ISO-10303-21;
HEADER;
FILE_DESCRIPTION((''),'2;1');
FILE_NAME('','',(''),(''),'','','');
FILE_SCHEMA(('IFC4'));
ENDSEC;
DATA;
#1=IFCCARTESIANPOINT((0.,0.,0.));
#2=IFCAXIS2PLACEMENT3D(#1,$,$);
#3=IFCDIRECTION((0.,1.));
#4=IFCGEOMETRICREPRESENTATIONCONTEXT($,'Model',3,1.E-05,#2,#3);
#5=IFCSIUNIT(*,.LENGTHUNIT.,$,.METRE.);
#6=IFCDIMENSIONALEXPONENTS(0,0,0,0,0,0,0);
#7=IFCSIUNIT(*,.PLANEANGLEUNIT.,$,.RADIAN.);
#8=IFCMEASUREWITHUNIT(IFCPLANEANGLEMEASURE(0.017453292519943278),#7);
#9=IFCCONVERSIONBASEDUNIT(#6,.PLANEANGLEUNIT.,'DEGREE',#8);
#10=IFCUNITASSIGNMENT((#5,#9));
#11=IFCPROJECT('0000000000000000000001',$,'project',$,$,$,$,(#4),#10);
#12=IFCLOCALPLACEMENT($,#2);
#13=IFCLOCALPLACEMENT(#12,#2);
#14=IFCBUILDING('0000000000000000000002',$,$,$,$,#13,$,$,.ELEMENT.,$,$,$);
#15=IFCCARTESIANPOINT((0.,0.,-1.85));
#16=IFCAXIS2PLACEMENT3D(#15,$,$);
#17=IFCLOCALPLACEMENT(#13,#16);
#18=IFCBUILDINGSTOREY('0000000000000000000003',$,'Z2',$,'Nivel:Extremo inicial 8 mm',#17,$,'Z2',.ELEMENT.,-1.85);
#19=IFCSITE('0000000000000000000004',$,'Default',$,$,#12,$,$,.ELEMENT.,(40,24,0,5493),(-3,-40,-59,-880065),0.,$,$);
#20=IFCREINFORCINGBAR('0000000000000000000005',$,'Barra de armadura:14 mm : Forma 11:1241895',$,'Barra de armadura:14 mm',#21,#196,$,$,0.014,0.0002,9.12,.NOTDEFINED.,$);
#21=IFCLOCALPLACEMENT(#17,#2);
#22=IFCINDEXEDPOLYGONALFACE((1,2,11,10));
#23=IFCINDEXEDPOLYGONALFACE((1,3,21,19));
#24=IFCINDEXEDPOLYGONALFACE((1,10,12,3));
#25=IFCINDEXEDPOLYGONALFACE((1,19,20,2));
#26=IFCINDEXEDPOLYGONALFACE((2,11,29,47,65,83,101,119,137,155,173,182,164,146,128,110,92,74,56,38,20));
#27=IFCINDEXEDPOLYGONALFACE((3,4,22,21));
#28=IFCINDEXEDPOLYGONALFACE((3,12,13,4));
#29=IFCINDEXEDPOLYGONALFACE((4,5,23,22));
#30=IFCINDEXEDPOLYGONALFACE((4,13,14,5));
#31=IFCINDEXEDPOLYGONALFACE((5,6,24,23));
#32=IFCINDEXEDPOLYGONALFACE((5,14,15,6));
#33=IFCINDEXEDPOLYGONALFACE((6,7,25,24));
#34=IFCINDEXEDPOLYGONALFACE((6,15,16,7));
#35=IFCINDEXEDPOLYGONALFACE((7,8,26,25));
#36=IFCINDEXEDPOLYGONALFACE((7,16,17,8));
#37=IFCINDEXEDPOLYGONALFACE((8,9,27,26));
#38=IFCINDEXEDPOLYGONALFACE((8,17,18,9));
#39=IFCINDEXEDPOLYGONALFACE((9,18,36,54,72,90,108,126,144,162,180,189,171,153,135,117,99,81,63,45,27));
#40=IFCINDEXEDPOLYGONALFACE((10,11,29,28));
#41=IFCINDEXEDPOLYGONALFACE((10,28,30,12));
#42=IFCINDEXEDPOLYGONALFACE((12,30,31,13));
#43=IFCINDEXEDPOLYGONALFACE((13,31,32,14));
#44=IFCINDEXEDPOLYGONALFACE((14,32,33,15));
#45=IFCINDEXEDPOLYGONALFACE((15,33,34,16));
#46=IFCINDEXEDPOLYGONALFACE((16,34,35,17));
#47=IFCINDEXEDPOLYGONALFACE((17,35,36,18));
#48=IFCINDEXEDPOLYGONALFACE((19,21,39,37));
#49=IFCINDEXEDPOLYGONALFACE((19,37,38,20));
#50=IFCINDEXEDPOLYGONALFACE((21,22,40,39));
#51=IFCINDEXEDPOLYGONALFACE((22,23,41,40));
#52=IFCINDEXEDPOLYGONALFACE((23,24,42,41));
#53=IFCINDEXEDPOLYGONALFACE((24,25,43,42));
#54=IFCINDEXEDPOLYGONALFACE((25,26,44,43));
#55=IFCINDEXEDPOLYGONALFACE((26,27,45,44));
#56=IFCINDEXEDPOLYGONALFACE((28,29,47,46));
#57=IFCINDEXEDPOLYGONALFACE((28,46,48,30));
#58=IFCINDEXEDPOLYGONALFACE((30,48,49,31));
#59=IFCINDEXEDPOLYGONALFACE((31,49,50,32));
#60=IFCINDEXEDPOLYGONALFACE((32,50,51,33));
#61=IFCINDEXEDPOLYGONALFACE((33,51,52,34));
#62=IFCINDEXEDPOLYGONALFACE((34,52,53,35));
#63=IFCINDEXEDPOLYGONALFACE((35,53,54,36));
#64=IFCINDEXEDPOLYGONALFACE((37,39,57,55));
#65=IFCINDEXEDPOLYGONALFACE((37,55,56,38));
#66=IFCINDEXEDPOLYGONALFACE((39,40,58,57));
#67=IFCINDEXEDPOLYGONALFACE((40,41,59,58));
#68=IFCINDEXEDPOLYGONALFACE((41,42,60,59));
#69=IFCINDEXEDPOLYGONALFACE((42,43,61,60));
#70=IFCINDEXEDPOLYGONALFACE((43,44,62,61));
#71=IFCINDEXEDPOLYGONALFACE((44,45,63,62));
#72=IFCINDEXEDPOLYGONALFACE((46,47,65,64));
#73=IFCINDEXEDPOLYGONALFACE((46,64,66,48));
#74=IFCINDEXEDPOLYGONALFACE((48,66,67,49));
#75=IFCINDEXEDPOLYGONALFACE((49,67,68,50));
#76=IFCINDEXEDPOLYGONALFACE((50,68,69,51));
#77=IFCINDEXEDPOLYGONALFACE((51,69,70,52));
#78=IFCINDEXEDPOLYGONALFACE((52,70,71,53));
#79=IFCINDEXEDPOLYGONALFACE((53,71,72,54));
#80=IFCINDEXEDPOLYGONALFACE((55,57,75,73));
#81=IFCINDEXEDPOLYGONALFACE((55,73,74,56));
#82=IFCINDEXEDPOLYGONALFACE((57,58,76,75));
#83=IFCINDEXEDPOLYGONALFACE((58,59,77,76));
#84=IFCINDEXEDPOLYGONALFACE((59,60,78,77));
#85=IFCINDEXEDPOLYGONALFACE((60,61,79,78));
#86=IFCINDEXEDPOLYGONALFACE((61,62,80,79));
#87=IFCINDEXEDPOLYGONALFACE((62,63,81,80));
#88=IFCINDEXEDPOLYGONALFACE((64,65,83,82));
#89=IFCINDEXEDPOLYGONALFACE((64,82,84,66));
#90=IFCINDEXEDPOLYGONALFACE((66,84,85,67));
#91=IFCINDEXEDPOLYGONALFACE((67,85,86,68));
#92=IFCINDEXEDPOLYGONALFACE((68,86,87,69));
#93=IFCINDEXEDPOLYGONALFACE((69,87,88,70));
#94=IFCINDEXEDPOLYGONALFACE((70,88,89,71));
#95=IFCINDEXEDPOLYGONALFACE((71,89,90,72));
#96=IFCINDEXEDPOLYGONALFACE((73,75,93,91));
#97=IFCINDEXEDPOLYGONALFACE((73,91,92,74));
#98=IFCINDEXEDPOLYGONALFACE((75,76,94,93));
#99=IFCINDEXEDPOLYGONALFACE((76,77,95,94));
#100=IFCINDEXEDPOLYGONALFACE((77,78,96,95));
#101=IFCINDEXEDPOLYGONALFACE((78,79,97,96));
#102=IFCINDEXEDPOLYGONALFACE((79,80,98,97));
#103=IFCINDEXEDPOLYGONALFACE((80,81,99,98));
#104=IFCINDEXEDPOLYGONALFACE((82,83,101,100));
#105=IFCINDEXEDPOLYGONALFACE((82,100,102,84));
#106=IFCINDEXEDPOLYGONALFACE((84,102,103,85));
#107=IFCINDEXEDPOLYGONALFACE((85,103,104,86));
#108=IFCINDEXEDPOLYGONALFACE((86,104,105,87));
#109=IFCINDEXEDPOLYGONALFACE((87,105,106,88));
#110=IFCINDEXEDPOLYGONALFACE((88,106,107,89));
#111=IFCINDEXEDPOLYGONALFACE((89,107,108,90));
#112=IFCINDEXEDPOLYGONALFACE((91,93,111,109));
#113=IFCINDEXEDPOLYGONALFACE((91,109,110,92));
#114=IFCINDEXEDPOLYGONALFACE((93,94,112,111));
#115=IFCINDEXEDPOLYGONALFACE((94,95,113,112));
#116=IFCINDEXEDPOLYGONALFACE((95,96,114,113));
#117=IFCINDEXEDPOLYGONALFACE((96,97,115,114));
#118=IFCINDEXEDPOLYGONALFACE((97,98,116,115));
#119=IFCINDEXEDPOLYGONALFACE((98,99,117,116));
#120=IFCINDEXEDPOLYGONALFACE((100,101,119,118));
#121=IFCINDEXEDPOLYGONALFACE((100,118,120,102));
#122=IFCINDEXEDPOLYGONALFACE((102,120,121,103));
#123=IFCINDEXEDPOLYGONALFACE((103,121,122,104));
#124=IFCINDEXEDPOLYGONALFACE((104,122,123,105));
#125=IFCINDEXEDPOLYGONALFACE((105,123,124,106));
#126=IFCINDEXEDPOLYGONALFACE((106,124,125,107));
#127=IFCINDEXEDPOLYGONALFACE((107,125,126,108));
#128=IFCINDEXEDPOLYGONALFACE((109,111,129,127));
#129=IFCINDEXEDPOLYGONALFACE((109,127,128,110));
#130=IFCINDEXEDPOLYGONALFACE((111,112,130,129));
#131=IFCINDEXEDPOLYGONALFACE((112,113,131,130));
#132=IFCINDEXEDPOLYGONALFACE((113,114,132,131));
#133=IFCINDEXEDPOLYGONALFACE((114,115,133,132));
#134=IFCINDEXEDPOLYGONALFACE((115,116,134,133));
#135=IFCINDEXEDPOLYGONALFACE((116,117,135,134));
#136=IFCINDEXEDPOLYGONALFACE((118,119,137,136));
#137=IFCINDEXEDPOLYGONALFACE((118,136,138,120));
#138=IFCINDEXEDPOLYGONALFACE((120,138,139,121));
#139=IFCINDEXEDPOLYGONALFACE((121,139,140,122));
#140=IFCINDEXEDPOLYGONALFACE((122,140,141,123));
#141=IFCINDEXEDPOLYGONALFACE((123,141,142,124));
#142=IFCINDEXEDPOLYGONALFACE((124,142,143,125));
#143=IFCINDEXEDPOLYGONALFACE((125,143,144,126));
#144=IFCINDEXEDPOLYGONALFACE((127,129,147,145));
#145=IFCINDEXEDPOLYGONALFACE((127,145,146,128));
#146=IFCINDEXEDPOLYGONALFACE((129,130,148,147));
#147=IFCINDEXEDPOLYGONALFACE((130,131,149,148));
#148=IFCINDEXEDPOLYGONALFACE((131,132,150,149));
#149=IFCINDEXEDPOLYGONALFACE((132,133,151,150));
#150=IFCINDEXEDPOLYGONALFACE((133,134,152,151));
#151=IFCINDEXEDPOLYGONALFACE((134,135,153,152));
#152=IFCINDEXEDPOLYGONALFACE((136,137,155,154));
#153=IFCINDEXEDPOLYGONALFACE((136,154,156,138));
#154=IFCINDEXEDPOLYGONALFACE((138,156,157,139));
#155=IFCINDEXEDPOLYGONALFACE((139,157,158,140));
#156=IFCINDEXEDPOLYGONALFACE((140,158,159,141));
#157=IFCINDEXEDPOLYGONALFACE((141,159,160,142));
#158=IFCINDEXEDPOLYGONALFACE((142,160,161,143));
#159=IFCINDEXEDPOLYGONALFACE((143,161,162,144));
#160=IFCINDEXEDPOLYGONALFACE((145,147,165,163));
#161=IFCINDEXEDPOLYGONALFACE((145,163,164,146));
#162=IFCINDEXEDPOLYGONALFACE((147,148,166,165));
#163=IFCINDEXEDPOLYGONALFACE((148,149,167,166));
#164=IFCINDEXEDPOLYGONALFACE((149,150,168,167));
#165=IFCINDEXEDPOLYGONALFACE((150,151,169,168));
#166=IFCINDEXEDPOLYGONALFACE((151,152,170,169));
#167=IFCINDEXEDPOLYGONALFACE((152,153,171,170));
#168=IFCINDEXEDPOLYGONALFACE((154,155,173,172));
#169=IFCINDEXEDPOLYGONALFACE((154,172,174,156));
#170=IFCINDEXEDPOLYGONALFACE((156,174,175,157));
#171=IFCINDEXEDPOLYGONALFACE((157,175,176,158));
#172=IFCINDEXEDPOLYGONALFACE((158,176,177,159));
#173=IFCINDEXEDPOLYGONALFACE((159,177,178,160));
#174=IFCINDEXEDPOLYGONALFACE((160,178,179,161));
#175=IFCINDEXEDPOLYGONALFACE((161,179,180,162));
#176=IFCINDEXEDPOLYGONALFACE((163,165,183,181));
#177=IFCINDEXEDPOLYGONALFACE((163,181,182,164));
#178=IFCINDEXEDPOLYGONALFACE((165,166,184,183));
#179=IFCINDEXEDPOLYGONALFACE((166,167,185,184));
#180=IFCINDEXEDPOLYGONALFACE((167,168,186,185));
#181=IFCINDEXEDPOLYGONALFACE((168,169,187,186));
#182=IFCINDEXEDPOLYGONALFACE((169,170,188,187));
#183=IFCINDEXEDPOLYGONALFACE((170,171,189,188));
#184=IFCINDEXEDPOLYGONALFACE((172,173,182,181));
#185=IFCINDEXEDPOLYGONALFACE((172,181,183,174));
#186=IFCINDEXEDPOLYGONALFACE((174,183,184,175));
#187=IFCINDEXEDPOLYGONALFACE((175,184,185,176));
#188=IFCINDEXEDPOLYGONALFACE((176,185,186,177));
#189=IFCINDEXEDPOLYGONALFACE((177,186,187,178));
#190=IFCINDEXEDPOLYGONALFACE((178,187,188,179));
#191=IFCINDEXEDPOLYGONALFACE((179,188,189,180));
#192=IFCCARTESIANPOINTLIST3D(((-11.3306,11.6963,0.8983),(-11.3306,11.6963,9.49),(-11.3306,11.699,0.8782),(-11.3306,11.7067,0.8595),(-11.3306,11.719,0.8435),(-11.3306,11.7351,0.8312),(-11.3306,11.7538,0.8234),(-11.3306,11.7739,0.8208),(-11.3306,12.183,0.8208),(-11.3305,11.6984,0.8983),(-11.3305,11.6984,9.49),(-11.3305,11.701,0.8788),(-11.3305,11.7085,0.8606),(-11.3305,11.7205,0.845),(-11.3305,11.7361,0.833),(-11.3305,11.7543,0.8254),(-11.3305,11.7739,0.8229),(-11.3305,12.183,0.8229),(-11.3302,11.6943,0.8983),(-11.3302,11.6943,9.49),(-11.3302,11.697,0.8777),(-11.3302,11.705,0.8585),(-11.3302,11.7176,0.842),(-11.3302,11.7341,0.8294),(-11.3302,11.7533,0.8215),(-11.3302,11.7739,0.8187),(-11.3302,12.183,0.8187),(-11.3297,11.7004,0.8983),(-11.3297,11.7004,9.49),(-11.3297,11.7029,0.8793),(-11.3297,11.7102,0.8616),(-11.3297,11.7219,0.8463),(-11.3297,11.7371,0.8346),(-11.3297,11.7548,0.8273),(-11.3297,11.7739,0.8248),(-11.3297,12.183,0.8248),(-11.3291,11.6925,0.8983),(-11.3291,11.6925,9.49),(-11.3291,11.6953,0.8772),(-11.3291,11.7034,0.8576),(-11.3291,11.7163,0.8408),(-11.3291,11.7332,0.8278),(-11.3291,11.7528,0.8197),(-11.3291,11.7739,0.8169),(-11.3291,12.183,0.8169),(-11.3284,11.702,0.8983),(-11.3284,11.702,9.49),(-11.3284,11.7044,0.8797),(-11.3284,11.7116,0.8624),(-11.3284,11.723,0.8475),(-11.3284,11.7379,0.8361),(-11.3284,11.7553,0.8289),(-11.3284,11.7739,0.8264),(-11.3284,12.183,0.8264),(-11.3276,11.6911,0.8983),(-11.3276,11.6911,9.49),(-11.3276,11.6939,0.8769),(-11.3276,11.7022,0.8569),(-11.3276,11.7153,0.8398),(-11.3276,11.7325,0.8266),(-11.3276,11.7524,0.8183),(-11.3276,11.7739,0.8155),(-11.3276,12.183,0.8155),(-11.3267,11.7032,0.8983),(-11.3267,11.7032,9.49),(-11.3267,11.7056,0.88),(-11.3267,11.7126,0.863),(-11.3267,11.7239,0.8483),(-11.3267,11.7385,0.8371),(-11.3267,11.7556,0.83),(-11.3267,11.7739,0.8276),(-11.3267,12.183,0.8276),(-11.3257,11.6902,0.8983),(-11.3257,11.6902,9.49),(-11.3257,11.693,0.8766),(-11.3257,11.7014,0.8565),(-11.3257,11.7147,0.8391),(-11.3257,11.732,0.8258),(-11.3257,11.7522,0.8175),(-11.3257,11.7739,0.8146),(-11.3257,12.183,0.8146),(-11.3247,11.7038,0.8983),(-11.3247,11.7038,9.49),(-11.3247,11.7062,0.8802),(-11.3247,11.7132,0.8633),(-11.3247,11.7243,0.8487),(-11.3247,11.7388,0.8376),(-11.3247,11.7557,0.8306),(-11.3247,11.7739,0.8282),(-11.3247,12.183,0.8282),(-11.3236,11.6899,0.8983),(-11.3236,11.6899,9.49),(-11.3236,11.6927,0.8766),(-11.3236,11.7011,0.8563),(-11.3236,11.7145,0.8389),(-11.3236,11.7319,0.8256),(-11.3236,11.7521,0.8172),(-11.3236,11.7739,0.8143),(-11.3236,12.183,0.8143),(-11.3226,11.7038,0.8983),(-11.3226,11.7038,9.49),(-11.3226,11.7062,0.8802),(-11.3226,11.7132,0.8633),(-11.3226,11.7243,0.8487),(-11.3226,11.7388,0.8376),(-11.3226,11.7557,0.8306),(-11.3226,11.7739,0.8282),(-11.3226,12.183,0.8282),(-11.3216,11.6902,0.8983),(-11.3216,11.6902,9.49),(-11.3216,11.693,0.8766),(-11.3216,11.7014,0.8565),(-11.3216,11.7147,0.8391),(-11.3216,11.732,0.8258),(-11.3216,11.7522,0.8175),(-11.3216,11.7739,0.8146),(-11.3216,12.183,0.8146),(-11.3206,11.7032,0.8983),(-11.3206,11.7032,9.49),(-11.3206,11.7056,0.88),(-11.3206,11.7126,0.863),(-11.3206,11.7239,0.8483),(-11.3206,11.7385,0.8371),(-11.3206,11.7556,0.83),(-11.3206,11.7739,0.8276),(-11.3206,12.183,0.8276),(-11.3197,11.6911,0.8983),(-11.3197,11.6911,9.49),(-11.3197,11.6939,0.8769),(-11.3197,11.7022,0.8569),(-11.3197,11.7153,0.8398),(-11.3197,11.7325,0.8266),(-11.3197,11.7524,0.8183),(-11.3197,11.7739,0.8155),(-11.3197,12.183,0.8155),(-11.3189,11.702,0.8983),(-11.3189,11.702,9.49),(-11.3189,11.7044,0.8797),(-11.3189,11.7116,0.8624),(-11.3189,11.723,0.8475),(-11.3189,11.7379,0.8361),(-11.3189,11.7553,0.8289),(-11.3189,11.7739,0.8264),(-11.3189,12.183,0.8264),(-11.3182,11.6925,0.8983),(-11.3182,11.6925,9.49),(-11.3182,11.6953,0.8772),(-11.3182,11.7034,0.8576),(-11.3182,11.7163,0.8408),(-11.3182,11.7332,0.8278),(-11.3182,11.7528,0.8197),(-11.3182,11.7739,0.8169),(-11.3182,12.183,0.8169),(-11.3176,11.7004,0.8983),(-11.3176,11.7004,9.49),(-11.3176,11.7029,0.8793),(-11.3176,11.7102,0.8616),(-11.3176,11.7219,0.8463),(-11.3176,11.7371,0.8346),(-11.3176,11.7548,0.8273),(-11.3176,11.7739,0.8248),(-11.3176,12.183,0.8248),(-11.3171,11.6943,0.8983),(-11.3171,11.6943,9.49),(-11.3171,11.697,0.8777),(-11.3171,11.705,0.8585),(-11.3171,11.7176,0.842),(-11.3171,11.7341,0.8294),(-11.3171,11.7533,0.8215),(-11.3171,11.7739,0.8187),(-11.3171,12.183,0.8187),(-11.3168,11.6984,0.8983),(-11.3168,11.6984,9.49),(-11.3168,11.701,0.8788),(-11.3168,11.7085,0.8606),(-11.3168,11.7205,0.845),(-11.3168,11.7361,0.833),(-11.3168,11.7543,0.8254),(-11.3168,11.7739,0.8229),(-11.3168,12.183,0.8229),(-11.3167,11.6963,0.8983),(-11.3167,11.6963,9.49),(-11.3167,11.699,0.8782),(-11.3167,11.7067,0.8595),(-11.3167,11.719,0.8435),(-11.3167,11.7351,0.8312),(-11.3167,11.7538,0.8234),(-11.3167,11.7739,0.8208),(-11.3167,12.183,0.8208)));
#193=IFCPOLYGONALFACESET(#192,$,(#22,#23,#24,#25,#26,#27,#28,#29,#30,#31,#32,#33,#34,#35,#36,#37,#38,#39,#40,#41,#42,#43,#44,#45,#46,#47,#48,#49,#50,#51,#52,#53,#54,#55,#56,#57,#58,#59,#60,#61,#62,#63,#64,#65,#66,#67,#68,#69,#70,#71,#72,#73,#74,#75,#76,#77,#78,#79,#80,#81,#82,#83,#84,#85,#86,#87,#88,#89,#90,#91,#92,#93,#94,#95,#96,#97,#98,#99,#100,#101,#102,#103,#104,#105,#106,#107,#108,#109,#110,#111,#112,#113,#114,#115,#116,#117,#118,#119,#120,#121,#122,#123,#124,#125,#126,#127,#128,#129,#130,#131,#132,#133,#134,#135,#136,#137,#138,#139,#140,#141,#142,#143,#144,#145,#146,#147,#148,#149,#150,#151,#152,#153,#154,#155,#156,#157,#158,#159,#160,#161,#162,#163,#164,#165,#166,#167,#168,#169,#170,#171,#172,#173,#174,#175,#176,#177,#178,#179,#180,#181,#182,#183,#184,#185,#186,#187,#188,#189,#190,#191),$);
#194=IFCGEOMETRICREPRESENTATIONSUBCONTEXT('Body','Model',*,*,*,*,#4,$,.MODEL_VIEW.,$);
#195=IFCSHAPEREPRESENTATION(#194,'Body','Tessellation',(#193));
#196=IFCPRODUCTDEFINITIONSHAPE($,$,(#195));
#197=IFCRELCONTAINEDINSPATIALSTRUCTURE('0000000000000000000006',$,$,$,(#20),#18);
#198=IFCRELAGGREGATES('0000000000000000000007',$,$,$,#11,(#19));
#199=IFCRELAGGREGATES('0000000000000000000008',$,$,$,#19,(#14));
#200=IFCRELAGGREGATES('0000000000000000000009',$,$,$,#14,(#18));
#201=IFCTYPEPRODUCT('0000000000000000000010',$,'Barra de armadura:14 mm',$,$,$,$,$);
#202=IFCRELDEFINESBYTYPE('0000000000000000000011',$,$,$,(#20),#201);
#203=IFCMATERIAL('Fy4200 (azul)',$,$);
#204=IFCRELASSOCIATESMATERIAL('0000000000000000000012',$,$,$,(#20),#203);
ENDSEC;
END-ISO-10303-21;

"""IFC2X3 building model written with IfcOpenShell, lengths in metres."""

from ifc_helpers import new_model, entity, si_unit, converted_unit, direction, frame, origin, place, context, subcontext, project, spatial, material, type_object, element, save


model = new_model("IFC2X3")

# Units and contexts
model_context = context("Model", 3, precision=1e-05, world=origin(), true_north=direction((0.0, 1.0)))
body_context = subcontext(model_context, "Body", "Model", "MODEL_VIEW")
ifc_project = project(units=[si_unit("LENGTHUNIT", "METRE"), converted_unit("PLANEANGLEUNIT", "DEGREE", entity("IfcPlaneAngleMeasure", 0.017453292519943278), si_unit("PLANEANGLEUNIT", "RADIAN"), dimensions=[0, 0, 0, 0, 0, 0, 0])], contexts=[model_context])

# Site, building, storey
site_placement = place(None, origin())
site = spatial("IfcSite", under=ifc_project, at=site_placement, Name="Default", CompositionType="ELEMENT", RefLatitude=(40, 24, 0, 5493), RefLongitude=(-3, -40, -59, -880065), RefElevation=0.0)
building_placement = place(site_placement, origin())
building = spatial("IfcBuilding", under=site, at=building_placement, CompositionType="ELEMENT")
storey_placement = place(building_placement, frame((0.0, 0.0, -1.85)))
storey = spatial("IfcBuildingStorey", under=building, at=storey_placement, Name="Z2", ObjectType="Nivel:Extremo inicial 8 mm", LongName="Z2", CompositionType="ELEMENT", Elevation=-1.85)

# Reinforcing bar
ifc_material_1 = material(Name="Fy4200 (azul)")
type_product_1 = type_object("IfcTypeProduct", Name="Barra de armadura:14 mm")
reinforcing_bar_1_placement = place(storey_placement, origin())
element("IfcReinforcingBar", 1, at=reinforcing_bar_1_placement, inside=storey, type_object=type_product_1, material=ifc_material_1, Name="Barra de armadura:14 mm : Forma 11:1241895", ObjectType="Barra de armadura:14 mm", BarLength=9.12, BarRole="NOTDEFINED", CrossSectionArea=0.0002, NominalDiameter=0.014, context=body_context, shape_type="AdvancedSweptSolid", body=[
    entity("IfcSweptDiskSolid", entity("IfcCompositeCurve", [entity("IfcCompositeCurveSegment", "CONTINUOUS", True, entity("IfcPolyline", [entity("IfcCartesianPoint", [-11.3236, 11.6969, 9.49]), entity("IfcCartesianPoint", [-11.3236, 11.6969, 0.8983])])), entity("IfcCompositeCurveSegment", "CONTINUOUS", True, entity("IfcTrimmedCurve", entity("IfcCircle", entity("IfcAxis2Placement3D", entity("IfcCartesianPoint", [-11.3236, 11.7739, 0.8983]), entity("IfcDirection", [1.0, 0.0, 0.0]), entity("IfcDirection", [0.0, 0.0, -1.0])), 0.077), [entity("IfcParameterValue", 270.0)], [entity("IfcParameterValue", 360.0)], True, "PARAMETER")), entity("IfcCompositeCurveSegment", "CONTINUOUS", True, entity("IfcPolyline", [entity("IfcCartesianPoint", [-11.3236, 11.7739, 0.8213]), entity("IfcCartesianPoint", [-11.3236, 12.183, 0.8213])]))], False), 0.007, None, 0.0, 92.0),
])

save(model, "model.ifc")
